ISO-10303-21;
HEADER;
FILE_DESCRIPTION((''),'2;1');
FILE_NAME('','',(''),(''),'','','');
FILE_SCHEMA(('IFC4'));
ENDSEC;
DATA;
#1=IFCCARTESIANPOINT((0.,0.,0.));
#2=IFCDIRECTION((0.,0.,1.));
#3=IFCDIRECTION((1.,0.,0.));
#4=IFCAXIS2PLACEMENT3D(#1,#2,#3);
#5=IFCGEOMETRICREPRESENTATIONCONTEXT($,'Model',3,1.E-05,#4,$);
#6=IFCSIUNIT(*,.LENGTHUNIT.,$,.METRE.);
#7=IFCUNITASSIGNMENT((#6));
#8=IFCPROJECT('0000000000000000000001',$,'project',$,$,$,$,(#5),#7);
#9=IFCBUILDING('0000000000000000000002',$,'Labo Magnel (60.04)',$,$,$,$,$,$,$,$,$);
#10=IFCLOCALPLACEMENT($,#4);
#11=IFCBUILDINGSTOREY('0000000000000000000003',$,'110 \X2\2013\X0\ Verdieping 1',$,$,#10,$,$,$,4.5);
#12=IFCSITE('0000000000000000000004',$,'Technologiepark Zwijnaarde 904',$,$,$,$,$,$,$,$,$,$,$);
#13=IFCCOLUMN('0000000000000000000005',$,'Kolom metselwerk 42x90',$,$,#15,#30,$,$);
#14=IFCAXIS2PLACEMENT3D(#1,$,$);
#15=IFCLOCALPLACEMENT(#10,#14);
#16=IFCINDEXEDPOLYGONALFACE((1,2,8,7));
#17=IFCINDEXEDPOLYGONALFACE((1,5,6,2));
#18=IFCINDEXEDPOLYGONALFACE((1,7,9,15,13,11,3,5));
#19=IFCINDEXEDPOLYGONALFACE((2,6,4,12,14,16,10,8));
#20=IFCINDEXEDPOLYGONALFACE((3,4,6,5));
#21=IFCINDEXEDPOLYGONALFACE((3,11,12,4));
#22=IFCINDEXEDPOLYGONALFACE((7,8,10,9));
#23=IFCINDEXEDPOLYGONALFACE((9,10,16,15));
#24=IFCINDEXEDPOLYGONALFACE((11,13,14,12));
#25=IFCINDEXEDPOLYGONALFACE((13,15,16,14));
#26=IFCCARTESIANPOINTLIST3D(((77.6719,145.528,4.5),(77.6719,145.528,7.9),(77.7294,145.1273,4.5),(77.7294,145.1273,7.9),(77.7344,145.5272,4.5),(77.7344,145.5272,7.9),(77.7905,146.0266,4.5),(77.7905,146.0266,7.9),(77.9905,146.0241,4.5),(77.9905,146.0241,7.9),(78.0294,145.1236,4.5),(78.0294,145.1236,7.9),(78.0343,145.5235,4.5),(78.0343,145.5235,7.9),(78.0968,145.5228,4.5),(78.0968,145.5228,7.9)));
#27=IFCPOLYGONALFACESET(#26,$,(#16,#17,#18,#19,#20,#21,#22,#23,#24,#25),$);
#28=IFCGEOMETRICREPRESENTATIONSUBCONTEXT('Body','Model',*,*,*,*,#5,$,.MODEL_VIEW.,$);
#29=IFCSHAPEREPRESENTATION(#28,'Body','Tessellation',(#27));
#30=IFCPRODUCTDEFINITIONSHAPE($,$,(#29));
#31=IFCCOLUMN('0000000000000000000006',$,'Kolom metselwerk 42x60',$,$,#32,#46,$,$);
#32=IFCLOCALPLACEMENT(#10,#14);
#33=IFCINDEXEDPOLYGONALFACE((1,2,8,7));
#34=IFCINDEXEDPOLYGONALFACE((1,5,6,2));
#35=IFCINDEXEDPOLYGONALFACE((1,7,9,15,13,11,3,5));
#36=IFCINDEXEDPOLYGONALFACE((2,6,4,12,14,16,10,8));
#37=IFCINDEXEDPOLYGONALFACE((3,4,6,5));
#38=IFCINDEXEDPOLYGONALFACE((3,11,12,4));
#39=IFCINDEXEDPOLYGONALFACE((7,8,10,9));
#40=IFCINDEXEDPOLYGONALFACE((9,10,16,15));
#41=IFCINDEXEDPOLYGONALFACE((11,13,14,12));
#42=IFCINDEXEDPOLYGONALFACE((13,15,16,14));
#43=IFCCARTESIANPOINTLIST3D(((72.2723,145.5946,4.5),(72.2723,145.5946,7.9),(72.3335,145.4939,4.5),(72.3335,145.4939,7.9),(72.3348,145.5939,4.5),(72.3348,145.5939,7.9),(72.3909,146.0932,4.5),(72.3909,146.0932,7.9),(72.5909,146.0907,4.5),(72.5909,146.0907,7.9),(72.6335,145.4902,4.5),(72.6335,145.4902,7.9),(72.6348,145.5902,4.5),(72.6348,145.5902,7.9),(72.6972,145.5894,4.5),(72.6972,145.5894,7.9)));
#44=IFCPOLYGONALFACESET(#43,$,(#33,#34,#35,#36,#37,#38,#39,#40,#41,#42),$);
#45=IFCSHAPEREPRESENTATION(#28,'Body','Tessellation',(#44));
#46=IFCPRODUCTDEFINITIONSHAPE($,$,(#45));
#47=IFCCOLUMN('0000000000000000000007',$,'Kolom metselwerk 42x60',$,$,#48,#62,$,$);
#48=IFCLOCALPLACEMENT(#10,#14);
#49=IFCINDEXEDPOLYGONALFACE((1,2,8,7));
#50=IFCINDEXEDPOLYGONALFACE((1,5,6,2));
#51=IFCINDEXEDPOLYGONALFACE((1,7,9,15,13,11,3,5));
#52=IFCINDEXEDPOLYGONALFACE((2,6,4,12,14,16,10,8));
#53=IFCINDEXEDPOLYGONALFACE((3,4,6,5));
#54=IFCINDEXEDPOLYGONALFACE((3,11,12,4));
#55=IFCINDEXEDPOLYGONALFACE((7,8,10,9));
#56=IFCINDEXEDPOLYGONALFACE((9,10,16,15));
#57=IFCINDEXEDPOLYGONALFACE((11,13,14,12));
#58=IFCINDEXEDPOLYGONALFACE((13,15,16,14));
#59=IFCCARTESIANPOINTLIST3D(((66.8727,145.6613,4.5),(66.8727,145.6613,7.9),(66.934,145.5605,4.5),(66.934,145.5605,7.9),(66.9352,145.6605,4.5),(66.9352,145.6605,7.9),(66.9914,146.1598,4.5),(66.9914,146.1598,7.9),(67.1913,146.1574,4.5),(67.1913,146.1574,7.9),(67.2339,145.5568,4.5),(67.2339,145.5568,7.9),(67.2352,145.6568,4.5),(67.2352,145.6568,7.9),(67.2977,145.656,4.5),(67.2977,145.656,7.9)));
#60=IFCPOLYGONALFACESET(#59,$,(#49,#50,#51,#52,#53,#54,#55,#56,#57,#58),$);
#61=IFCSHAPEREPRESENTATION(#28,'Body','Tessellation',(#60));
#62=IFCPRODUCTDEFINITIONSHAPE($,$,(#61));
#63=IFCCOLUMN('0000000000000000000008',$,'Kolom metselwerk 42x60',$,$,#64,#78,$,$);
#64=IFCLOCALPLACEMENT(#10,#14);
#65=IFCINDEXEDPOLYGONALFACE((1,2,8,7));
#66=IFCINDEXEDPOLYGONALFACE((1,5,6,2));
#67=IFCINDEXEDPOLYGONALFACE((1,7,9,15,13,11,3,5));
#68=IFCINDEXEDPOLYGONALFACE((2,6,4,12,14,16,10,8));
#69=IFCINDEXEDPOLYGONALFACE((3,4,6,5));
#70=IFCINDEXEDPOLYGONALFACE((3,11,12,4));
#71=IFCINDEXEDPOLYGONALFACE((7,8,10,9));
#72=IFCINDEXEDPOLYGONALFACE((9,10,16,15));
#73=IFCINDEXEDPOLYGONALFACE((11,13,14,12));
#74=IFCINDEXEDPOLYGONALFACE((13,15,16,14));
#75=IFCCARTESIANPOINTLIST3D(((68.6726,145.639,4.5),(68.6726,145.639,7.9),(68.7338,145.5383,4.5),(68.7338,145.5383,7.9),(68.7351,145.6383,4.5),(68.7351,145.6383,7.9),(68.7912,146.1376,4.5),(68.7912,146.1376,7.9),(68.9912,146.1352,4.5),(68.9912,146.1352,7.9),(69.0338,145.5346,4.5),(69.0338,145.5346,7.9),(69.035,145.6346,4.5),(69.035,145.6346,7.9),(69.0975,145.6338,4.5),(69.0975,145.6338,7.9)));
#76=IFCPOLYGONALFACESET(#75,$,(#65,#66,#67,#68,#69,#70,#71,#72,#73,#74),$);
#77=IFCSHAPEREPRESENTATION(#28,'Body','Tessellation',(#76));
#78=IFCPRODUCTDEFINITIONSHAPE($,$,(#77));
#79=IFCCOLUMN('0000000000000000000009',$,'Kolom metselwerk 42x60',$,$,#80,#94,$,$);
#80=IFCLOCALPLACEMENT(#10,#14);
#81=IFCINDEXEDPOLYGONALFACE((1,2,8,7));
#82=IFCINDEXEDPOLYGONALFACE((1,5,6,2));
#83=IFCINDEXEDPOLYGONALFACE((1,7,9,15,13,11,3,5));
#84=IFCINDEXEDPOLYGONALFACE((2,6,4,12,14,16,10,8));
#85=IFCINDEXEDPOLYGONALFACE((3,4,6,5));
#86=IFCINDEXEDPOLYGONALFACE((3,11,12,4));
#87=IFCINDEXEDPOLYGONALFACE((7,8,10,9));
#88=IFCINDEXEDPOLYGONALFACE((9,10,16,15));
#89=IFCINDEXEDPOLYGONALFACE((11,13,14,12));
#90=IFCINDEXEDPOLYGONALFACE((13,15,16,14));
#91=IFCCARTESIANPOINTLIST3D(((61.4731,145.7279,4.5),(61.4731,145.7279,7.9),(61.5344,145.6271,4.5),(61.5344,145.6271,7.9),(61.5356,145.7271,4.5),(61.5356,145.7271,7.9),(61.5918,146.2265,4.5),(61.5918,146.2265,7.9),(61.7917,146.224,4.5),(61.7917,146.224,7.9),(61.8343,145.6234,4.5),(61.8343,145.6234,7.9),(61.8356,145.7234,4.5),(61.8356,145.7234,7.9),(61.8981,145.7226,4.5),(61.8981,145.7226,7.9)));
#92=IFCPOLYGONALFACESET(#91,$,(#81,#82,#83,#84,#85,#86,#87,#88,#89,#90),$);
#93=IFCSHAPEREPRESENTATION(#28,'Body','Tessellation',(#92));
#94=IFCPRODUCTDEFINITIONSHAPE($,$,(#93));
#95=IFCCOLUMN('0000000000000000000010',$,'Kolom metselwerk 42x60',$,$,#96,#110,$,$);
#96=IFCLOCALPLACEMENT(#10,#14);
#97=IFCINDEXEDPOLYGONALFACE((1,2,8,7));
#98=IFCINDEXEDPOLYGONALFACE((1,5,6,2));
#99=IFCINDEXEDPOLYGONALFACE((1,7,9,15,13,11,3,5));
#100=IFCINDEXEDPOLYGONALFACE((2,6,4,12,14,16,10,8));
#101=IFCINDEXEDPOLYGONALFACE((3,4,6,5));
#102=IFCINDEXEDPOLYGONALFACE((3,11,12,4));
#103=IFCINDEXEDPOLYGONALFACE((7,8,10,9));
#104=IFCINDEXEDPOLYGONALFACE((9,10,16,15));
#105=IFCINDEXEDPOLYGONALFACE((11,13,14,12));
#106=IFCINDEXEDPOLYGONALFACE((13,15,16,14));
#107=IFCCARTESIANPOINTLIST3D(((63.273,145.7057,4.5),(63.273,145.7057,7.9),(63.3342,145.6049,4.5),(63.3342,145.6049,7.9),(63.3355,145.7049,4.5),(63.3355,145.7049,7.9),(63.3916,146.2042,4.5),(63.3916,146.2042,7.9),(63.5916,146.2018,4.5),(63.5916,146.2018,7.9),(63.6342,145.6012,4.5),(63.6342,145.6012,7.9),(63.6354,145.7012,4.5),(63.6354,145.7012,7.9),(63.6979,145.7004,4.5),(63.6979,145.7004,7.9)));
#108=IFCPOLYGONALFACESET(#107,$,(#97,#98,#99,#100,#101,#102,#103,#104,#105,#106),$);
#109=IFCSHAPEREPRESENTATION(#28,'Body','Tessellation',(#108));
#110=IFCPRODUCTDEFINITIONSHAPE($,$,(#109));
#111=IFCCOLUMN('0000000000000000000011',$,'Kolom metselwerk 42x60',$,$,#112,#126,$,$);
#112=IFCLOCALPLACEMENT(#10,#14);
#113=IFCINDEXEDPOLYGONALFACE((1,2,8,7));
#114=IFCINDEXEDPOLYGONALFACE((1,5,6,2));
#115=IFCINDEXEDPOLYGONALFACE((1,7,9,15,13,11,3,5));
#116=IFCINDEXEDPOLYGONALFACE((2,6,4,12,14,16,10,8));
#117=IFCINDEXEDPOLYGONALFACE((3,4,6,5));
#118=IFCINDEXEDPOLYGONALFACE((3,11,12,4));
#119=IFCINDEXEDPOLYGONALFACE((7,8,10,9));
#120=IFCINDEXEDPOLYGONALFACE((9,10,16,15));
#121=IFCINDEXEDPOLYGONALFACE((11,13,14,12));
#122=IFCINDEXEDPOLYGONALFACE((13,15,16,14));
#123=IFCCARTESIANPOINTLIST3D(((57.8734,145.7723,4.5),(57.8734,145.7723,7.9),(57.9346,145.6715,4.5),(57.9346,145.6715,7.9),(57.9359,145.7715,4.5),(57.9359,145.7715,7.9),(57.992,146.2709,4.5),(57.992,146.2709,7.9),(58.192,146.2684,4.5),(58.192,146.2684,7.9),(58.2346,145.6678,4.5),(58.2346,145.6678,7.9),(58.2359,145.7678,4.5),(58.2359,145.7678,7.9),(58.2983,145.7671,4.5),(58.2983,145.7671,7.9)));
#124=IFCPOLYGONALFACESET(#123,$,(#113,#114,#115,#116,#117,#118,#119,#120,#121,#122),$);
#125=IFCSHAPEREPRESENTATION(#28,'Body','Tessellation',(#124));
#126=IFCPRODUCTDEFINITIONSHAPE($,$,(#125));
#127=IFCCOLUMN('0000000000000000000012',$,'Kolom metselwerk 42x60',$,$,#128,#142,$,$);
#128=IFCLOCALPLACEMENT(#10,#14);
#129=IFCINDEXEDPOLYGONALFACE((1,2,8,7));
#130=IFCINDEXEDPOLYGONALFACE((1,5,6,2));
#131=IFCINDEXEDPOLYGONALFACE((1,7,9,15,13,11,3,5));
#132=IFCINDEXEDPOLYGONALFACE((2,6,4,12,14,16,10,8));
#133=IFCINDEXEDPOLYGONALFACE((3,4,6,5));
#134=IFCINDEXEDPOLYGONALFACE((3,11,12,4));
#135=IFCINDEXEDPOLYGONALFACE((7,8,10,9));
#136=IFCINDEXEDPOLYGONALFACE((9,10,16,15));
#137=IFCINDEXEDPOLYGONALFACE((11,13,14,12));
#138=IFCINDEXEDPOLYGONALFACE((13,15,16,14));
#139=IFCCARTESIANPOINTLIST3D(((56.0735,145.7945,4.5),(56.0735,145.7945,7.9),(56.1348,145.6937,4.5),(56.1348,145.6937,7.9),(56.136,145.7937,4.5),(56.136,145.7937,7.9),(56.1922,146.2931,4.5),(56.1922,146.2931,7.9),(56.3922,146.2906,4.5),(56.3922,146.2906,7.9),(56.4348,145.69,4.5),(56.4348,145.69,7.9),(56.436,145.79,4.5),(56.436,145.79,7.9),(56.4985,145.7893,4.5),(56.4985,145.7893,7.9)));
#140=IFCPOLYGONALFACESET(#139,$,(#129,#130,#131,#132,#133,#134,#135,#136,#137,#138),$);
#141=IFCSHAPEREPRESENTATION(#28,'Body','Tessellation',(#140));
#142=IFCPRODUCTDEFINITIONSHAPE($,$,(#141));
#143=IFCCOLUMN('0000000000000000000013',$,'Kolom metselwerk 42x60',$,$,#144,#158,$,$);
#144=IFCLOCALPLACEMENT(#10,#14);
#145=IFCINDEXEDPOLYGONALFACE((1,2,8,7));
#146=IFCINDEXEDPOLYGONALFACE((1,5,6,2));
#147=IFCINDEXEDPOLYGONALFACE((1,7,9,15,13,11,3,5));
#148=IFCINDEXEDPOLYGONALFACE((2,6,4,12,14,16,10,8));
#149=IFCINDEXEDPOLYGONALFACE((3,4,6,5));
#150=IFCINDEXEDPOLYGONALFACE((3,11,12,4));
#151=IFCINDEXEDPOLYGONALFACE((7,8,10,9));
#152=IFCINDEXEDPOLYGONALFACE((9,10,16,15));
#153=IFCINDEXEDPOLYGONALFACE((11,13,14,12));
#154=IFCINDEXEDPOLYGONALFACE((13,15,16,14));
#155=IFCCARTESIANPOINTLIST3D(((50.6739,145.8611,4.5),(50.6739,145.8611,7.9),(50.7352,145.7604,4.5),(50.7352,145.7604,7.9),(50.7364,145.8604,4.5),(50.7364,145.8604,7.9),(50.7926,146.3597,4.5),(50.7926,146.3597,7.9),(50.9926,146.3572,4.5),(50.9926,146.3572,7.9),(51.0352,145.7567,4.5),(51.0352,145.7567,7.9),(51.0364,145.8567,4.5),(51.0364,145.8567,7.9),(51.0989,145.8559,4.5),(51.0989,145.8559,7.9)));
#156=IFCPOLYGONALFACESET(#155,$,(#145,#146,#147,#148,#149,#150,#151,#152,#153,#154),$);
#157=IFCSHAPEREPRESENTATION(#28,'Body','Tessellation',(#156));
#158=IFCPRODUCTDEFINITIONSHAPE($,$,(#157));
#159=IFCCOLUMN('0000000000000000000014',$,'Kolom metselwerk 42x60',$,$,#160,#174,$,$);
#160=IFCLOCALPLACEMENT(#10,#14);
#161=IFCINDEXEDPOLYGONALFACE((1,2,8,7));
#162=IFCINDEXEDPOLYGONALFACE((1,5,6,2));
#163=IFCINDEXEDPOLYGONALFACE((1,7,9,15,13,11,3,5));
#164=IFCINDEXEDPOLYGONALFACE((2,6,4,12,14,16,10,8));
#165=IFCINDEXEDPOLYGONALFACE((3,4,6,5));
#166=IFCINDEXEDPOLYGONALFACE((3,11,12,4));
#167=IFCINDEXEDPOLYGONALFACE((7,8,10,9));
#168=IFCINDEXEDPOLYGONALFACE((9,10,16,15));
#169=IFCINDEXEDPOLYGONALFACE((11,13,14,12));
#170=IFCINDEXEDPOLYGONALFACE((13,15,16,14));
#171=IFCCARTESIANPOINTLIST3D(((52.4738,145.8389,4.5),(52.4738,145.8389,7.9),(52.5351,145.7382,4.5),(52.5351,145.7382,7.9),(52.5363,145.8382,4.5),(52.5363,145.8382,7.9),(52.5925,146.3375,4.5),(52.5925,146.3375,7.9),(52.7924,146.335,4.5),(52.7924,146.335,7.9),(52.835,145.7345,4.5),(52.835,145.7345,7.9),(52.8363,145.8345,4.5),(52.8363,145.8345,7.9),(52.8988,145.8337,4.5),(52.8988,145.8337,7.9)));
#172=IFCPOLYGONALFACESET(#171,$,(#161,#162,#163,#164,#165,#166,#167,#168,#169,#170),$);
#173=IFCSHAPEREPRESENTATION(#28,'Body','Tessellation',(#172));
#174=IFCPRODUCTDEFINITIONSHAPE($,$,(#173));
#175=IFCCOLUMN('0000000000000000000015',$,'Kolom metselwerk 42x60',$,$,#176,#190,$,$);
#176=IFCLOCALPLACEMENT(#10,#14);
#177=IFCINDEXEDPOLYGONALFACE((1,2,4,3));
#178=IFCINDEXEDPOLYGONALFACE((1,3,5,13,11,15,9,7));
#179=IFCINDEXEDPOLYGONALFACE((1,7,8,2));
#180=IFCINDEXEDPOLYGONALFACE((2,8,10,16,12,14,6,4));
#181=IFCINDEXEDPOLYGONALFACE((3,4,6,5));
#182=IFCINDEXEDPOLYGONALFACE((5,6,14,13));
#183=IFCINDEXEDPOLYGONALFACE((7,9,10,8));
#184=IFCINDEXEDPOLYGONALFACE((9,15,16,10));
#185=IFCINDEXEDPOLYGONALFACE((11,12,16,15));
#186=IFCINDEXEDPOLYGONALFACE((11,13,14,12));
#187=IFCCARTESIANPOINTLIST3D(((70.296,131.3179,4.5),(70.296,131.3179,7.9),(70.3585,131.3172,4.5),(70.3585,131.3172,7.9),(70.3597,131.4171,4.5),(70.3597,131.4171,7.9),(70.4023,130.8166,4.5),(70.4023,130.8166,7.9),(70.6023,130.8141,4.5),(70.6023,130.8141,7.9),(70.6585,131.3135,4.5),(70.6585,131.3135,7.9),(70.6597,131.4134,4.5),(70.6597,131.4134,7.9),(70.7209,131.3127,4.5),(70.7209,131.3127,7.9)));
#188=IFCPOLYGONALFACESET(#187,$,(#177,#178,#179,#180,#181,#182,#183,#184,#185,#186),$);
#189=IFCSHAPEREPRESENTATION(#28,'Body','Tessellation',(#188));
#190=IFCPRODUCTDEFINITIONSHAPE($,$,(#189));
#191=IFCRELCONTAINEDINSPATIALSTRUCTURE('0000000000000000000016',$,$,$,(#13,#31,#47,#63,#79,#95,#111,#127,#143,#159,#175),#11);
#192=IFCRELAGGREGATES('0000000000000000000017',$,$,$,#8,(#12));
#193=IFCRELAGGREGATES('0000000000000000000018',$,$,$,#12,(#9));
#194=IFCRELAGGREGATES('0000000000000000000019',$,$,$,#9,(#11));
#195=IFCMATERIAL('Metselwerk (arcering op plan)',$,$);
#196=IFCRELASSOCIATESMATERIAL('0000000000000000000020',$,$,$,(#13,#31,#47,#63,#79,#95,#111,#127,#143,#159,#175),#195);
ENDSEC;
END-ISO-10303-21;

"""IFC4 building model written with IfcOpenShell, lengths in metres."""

from ifc_helpers import new_model, si_unit, frame, origin, origin_with_axes, place, context, subcontext, project, spatial, polyline, outline, extrude, material, element, save


model = new_model("IFC4")

# Units and contexts
model_context = context("Model", 3, precision=1e-05, world=origin_with_axes())
body_context = subcontext(model_context, "Body", "Model", "MODEL_VIEW")
ifc_project = project(units=[si_unit("LENGTHUNIT", "METRE")], contexts=[model_context])

# Site, building, storey
site = spatial("IfcSite", under=ifc_project, Name="Technologiepark Zwijnaarde 904")
building = spatial("IfcBuilding", under=site, Name="Labo Magnel (60.04)")
storey_placement = place(None, origin_with_axes())
storey = spatial("IfcBuildingStorey", under=building, at=storey_placement, Name="110 – Verdieping 1", Elevation=4.5)

# Columns
ifc_material_1 = material(Name="Metselwerk (arcering op plan)")
column_1_placement = place(storey_placement, frame((0.0, 0.0, 4.5), z_axis=(0.0, 0.0, 1.0), x_axis=(1.0, 0.0, 0.0)))
element("IfcColumn", 1, at=column_1_placement, inside=storey, material=ifc_material_1, Name="Kolom metselwerk 42x90", context=body_context, shape_type="SweptSolid", body=[
    extrude(outline(polyline([(77.9905, 146.0241), (77.7905, 146.0266), (77.6719, 145.528), (77.7344, 145.5272), (77.7294, 145.1273), (78.0294, 145.1236), (78.0343, 145.5235), (78.0968, 145.5228), (77.9905, 146.0241)])), origin(), (0.0, 0.0, 1.0), 3.4),
])
column_2_placement = place(storey_placement, frame((0.0, 0.0, 4.5), z_axis=(0.0, 0.0, 1.0), x_axis=(1.0, 0.0, 0.0)))
element("IfcColumn", 2, at=column_2_placement, inside=storey, material=ifc_material_1, Name="Kolom metselwerk 42x60", context=body_context, shape_type="SweptSolid", body=[
    extrude(outline(polyline([(72.5909, 146.0907), (72.3909, 146.0932), (72.2723, 145.5946), (72.3348, 145.5939), (72.3335, 145.4939), (72.6335, 145.4902), (72.6348, 145.5902), (72.6972, 145.5894), (72.5909, 146.0907)])), origin(), (0.0, 0.0, 1.0), 3.4),
])
column_3_placement = place(storey_placement, frame((0.0, 0.0, 4.5), z_axis=(0.0, 0.0, 1.0), x_axis=(1.0, 0.0, 0.0)))
element("IfcColumn", 3, at=column_3_placement, inside=storey, material=ifc_material_1, Name="Kolom metselwerk 42x60", context=body_context, shape_type="SweptSolid", body=[
    extrude(outline(polyline([(67.1913, 146.1574), (66.9914, 146.1598), (66.8727, 145.6613), (66.9352, 145.6605), (66.934, 145.5605), (67.2339, 145.5568), (67.2352, 145.6568), (67.2977, 145.656), (67.1913, 146.1574)])), origin(), (0.0, 0.0, 1.0), 3.4),
])
column_4_placement = place(storey_placement, frame((0.0, 0.0, 4.5), z_axis=(0.0, 0.0, 1.0), x_axis=(1.0, 0.0, 0.0)))
element("IfcColumn", 4, at=column_4_placement, inside=storey, material=ifc_material_1, Name="Kolom metselwerk 42x60", context=body_context, shape_type="SweptSolid", body=[
    extrude(outline(polyline([(68.9912, 146.1352), (68.7912, 146.1376), (68.6726, 145.639), (68.7351, 145.6383), (68.7338, 145.5383), (69.0338, 145.5346), (69.035, 145.6346), (69.0975, 145.6338), (68.9912, 146.1352)])), origin(), (0.0, 0.0, 1.0), 3.4),
])
column_5_placement = place(storey_placement, frame((0.0, 0.0, 4.5), z_axis=(0.0, 0.0, 1.0), x_axis=(1.0, 0.0, 0.0)))
element("IfcColumn", 5, at=column_5_placement, inside=storey, material=ifc_material_1, Name="Kolom metselwerk 42x60", context=body_context, shape_type="SweptSolid", body=[
    extrude(outline(polyline([(61.7917, 146.224), (61.5918, 146.2265), (61.4731, 145.7279), (61.5356, 145.7271), (61.5344, 145.6271), (61.8343, 145.6234), (61.8356, 145.7234), (61.8981, 145.7226), (61.7917, 146.224)])), origin(), (0.0, 0.0, 1.0), 3.4),
])
column_6_placement = place(storey_placement, frame((0.0, 0.0, 4.5), z_axis=(0.0, 0.0, 1.0), x_axis=(1.0, 0.0, 0.0)))
element("IfcColumn", 6, at=column_6_placement, inside=storey, material=ifc_material_1, Name="Kolom metselwerk 42x60", context=body_context, shape_type="SweptSolid", body=[
    extrude(outline(polyline([(63.5916, 146.2018), (63.3916, 146.2042), (63.273, 145.7057), (63.3355, 145.7049), (63.3342, 145.6049), (63.6342, 145.6012), (63.6354, 145.7012), (63.6979, 145.7004), (63.5916, 146.2018)])), origin(), (0.0, 0.0, 1.0), 3.4),
])
column_7_placement = place(storey_placement, frame((0.0, 0.0, 4.5), z_axis=(0.0, 0.0, 1.0), x_axis=(1.0, 0.0, 0.0)))
element("IfcColumn", 7, at=column_7_placement, inside=storey, material=ifc_material_1, Name="Kolom metselwerk 42x60", context=body_context, shape_type="SweptSolid", body=[
    extrude(outline(polyline([(58.192, 146.2684), (57.992, 146.2709), (57.8734, 145.7723), (57.9359, 145.7715), (57.9346, 145.6715), (58.2346, 145.6678), (58.2359, 145.7678), (58.2983, 145.7671), (58.192, 146.2684)])), origin(), (0.0, 0.0, 1.0), 3.4),
])
column_8_placement = place(storey_placement, frame((0.0, 0.0, 4.5), z_axis=(0.0, 0.0, 1.0), x_axis=(1.0, 0.0, 0.0)))
element("IfcColumn", 8, at=column_8_placement, inside=storey, material=ifc_material_1, Name="Kolom metselwerk 42x60", context=body_context, shape_type="SweptSolid", body=[
    extrude(outline(polyline([(56.436, 145.79), (56.4985, 145.7893), (56.3922, 146.2906), (56.1922, 146.2931), (56.0735, 145.7945), (56.136, 145.7937), (56.1348, 145.6937), (56.4348, 145.69), (56.436, 145.79)])), origin(), (0.0, 0.0, 1.0), 3.4),
])
column_9_placement = place(storey_placement, frame((0.0, 0.0, 4.5), z_axis=(0.0, 0.0, 1.0), x_axis=(1.0, 0.0, 0.0)))
element("IfcColumn", 9, at=column_9_placement, inside=storey, material=ifc_material_1, Name="Kolom metselwerk 42x60", context=body_context, shape_type="SweptSolid", body=[
    extrude(outline(polyline([(50.9926, 146.3572), (50.7926, 146.3597), (50.6739, 145.8611), (50.7364, 145.8604), (50.7352, 145.7604), (51.0352, 145.7567), (51.0364, 145.8567), (51.0989, 145.8559), (50.9926, 146.3572)])), origin(), (0.0, 0.0, 1.0), 3.4),
])
column_10_placement = place(storey_placement, frame((0.0, 0.0, 4.5), z_axis=(0.0, 0.0, 1.0), x_axis=(1.0, 0.0, 0.0)))
element("IfcColumn", 10, at=column_10_placement, inside=storey, material=ifc_material_1, Name="Kolom metselwerk 42x60", context=body_context, shape_type="SweptSolid", body=[
    extrude(outline(polyline([(52.7924, 146.335), (52.5925, 146.3375), (52.4738, 145.8389), (52.5363, 145.8382), (52.5351, 145.7382), (52.835, 145.7345), (52.8363, 145.8345), (52.8988, 145.8337), (52.7924, 146.335)])), origin(), (0.0, 0.0, 1.0), 3.4),
])
column_11_placement = place(storey_placement, frame((0.0, 0.0, 4.5), z_axis=(0.0, 0.0, 1.0), x_axis=(1.0, 0.0, 0.0)))
element("IfcColumn", 11, at=column_11_placement, inside=storey, material=ifc_material_1, Name="Kolom metselwerk 42x60", context=body_context, shape_type="SweptSolid", body=[
    extrude(outline(polyline([(70.7209, 131.3127), (70.6585, 131.3135), (70.6597, 131.4134), (70.3597, 131.4171), (70.3585, 131.3172), (70.296, 131.3179), (70.4023, 130.8166), (70.6023, 130.8141), (70.7209, 131.3127)])), origin(), (0.0, 0.0, 1.0), 3.4),
])

save(model, "model.ifc")
